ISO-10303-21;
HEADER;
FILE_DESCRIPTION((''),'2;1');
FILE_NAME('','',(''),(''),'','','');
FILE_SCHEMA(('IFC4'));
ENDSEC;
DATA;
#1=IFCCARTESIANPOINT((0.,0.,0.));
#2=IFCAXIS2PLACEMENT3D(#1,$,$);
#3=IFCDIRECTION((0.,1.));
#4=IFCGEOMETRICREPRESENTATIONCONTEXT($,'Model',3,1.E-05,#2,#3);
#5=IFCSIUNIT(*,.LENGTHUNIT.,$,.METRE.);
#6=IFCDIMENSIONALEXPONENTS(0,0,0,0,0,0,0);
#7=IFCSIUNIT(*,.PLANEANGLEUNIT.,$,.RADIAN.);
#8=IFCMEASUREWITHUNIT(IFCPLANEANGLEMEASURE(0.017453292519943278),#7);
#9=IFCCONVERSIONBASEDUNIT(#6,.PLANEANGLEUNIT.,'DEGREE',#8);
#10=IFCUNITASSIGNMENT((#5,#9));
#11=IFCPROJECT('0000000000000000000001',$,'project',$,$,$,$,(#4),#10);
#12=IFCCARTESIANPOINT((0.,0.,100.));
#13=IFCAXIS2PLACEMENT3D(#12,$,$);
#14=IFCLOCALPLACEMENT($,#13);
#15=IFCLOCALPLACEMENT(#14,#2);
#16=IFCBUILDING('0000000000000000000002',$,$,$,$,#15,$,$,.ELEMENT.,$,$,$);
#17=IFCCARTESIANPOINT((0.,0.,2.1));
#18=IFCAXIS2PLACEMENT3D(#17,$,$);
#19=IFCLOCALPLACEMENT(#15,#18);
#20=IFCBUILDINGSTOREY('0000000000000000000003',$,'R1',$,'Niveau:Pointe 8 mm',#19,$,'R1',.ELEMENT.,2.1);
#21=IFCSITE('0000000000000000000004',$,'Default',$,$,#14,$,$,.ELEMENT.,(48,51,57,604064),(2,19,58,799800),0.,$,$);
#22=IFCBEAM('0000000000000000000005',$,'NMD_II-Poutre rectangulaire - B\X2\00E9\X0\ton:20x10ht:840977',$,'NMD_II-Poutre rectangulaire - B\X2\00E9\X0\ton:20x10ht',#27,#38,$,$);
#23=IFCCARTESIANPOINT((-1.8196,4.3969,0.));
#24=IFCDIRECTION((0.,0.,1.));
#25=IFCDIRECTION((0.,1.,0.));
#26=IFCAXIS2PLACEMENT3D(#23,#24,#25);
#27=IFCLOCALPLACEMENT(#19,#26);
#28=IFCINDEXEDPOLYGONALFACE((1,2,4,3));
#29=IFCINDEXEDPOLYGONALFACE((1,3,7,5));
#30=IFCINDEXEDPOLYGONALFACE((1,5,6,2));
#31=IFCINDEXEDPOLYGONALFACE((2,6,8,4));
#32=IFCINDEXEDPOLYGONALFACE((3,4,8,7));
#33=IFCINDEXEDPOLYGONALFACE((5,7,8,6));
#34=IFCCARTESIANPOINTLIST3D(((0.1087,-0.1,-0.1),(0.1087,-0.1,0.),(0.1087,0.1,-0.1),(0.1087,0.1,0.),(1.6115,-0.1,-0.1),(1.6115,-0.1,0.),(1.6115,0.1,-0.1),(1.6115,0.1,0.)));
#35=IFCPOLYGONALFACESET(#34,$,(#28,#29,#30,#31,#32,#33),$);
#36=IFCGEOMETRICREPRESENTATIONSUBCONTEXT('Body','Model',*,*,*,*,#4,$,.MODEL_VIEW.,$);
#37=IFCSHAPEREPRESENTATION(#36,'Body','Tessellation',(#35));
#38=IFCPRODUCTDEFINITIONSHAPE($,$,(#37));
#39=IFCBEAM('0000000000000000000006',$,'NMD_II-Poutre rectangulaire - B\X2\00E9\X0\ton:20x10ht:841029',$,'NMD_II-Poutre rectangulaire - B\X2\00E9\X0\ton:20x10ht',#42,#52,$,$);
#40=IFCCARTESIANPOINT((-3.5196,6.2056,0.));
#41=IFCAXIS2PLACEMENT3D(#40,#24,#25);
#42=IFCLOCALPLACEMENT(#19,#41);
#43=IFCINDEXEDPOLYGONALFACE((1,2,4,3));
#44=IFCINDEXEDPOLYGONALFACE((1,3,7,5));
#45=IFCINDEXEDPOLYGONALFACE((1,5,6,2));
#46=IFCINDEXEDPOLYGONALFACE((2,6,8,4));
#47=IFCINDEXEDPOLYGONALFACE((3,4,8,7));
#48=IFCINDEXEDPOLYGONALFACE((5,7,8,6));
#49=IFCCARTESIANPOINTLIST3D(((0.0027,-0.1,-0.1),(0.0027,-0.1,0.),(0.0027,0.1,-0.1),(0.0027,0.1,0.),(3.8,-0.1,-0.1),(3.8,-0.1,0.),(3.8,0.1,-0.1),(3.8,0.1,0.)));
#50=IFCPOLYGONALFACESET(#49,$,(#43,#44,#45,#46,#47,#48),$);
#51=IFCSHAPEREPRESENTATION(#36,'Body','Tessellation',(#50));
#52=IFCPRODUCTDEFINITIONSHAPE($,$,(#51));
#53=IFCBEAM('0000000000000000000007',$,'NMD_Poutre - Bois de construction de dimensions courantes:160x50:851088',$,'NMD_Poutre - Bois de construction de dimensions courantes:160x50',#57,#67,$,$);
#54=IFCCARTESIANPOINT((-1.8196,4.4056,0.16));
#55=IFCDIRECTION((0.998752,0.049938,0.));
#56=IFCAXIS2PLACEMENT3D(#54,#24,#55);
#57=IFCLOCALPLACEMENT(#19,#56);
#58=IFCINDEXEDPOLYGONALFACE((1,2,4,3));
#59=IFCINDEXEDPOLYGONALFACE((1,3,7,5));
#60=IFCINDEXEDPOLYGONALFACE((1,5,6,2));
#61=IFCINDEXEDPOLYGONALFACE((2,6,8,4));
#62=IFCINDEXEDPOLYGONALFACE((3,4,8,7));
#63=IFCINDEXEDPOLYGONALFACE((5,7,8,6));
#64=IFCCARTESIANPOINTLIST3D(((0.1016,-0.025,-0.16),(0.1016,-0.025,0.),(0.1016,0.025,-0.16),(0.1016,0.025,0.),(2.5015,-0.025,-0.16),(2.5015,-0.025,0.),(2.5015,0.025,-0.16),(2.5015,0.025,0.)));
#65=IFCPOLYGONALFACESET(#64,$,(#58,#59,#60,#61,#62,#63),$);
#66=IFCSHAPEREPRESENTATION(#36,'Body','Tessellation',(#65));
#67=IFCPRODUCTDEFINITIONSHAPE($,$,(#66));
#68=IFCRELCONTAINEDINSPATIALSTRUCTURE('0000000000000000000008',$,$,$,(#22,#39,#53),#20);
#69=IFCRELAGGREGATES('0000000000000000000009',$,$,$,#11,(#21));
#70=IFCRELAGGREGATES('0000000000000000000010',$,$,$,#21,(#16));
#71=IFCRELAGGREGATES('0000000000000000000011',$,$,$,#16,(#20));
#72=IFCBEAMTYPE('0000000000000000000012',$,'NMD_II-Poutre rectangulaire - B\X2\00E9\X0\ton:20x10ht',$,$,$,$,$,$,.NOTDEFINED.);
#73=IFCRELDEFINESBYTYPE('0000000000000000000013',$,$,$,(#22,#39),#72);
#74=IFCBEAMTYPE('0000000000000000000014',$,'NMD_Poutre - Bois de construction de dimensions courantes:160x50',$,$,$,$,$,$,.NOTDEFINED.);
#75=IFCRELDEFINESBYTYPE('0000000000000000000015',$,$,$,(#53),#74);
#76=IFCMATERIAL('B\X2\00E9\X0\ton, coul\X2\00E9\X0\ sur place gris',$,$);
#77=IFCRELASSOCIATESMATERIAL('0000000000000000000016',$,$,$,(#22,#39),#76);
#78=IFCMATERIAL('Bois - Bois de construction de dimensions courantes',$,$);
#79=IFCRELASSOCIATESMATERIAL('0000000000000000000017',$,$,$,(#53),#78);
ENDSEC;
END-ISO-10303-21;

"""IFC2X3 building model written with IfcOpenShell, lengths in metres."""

from ifc_helpers import new_model, entity, si_unit, converted_unit, direction, frame, frame_2d, origin, origin_2d_with_axis, place, context, subcontext, project, spatial, rectangle, extrude, material, type_object, element, save


model = new_model("IFC2X3")

# Units and contexts
model_context = context("Model", 3, precision=1e-05, world=origin(), true_north=direction((0.0, 1.0)))
body_context = subcontext(model_context, "Body", "Model", "MODEL_VIEW")
ifc_project = project(units=[si_unit("LENGTHUNIT", "METRE"), converted_unit("PLANEANGLEUNIT", "DEGREE", entity("IfcPlaneAngleMeasure", 0.017453292519943278), si_unit("PLANEANGLEUNIT", "RADIAN"), dimensions=[0, 0, 0, 0, 0, 0, 0])], contexts=[model_context])

# Site, building, storey
site_placement = place(None, frame((0.0, 0.0, 100.0)))
site = spatial("IfcSite", under=ifc_project, at=site_placement, Name="Default", CompositionType="ELEMENT", RefLatitude=(48, 51, 57, 604064), RefLongitude=(2, 19, 58, 799800), RefElevation=0.0)
building_placement = place(site_placement, origin())
building = spatial("IfcBuilding", under=site, at=building_placement, CompositionType="ELEMENT")
storey_placement = place(building_placement, frame((0.0, 0.0, 2.1)))
storey = spatial("IfcBuildingStorey", under=building, at=storey_placement, Name="R1", ObjectType="Niveau:Pointe 8 mm", LongName="R1", CompositionType="ELEMENT", Elevation=2.1)

# Beams
ifc_material_1 = material(Name="Béton, coulé sur place gris")
beam_type_1 = type_object("IfcBeamType", Name="NMD_II-Poutre rectangulaire - Béton:20x10ht", PredefinedType="NOTDEFINED")
beam_1_placement = place(storey_placement, frame((-1.8196, 4.3969, 0.0), z_axis=(0.0, 0.0, 1.0), x_axis=(0.0, 1.0, 0.0)))
element("IfcBeam", 1, at=beam_1_placement, inside=storey, type_object=beam_type_1, material=ifc_material_1, Name="NMD_II-Poutre rectangulaire - Béton:20x10ht:840977", ObjectType="NMD_II-Poutre rectangulaire - Béton:20x10ht", context=body_context, shape_type="SweptSolid", body=[
    extrude(rectangle(XDim=0.1, YDim=0.2, at=origin_2d_with_axis()), frame((0.1087, 0.0, -0.05), z_axis=(1.0, 0.0, 0.0), x_axis=(0.0, 0.0, -1.0)), (0.0, 0.0, 1.0), 1.5027),
])
beam_2_placement = place(storey_placement, frame((-3.5196, 6.2056, 0.0), z_axis=(0.0, 0.0, 1.0), x_axis=(0.0, 1.0, 0.0)))
element("IfcBeam", 2, at=beam_2_placement, inside=storey, type_object=beam_type_1, material=ifc_material_1, Name="NMD_II-Poutre rectangulaire - Béton:20x10ht:841029", ObjectType="NMD_II-Poutre rectangulaire - Béton:20x10ht", context=body_context, shape_type="SweptSolid", body=[
    extrude(rectangle(XDim=0.1, YDim=0.2, at=frame_2d((0.0, 0.0), x_axis=(1.0, 0.0))), frame((0.0027, 0.0, -0.05), z_axis=(1.0, 0.0, 0.0), x_axis=(0.0, 0.0, -1.0)), (0.0, 0.0, 1.0), 3.7973),
])
ifc_material_2 = material(Name="Bois - Bois de construction de dimensions courantes")
beam_type_2 = type_object("IfcBeamType", Name="NMD_Poutre - Bois de construction de dimensions courantes:160x50", PredefinedType="NOTDEFINED")
beam_3_placement = place(storey_placement, frame((-1.8196, 4.4056, 0.16), z_axis=(0.0, 0.0, 1.0), x_axis=(0.998752, 0.049938, 0.0)))
element("IfcBeam", 3, at=beam_3_placement, inside=storey, type_object=beam_type_2, material=ifc_material_2, Name="NMD_Poutre - Bois de construction de dimensions courantes:160x50:851088", ObjectType="NMD_Poutre - Bois de construction de dimensions courantes:160x50", context=body_context, shape_type="SweptSolid", body=[
    extrude(rectangle(XDim=0.16, YDim=0.05, at=origin_2d_with_axis()), frame((0.1016, 0.0, -0.08), z_axis=(1.0, 0.0, 0.0), x_axis=(0.0, 0.0, -1.0)), (0.0, 0.0, 1.0), 2.4),
])

save(model, "model.ifc")
